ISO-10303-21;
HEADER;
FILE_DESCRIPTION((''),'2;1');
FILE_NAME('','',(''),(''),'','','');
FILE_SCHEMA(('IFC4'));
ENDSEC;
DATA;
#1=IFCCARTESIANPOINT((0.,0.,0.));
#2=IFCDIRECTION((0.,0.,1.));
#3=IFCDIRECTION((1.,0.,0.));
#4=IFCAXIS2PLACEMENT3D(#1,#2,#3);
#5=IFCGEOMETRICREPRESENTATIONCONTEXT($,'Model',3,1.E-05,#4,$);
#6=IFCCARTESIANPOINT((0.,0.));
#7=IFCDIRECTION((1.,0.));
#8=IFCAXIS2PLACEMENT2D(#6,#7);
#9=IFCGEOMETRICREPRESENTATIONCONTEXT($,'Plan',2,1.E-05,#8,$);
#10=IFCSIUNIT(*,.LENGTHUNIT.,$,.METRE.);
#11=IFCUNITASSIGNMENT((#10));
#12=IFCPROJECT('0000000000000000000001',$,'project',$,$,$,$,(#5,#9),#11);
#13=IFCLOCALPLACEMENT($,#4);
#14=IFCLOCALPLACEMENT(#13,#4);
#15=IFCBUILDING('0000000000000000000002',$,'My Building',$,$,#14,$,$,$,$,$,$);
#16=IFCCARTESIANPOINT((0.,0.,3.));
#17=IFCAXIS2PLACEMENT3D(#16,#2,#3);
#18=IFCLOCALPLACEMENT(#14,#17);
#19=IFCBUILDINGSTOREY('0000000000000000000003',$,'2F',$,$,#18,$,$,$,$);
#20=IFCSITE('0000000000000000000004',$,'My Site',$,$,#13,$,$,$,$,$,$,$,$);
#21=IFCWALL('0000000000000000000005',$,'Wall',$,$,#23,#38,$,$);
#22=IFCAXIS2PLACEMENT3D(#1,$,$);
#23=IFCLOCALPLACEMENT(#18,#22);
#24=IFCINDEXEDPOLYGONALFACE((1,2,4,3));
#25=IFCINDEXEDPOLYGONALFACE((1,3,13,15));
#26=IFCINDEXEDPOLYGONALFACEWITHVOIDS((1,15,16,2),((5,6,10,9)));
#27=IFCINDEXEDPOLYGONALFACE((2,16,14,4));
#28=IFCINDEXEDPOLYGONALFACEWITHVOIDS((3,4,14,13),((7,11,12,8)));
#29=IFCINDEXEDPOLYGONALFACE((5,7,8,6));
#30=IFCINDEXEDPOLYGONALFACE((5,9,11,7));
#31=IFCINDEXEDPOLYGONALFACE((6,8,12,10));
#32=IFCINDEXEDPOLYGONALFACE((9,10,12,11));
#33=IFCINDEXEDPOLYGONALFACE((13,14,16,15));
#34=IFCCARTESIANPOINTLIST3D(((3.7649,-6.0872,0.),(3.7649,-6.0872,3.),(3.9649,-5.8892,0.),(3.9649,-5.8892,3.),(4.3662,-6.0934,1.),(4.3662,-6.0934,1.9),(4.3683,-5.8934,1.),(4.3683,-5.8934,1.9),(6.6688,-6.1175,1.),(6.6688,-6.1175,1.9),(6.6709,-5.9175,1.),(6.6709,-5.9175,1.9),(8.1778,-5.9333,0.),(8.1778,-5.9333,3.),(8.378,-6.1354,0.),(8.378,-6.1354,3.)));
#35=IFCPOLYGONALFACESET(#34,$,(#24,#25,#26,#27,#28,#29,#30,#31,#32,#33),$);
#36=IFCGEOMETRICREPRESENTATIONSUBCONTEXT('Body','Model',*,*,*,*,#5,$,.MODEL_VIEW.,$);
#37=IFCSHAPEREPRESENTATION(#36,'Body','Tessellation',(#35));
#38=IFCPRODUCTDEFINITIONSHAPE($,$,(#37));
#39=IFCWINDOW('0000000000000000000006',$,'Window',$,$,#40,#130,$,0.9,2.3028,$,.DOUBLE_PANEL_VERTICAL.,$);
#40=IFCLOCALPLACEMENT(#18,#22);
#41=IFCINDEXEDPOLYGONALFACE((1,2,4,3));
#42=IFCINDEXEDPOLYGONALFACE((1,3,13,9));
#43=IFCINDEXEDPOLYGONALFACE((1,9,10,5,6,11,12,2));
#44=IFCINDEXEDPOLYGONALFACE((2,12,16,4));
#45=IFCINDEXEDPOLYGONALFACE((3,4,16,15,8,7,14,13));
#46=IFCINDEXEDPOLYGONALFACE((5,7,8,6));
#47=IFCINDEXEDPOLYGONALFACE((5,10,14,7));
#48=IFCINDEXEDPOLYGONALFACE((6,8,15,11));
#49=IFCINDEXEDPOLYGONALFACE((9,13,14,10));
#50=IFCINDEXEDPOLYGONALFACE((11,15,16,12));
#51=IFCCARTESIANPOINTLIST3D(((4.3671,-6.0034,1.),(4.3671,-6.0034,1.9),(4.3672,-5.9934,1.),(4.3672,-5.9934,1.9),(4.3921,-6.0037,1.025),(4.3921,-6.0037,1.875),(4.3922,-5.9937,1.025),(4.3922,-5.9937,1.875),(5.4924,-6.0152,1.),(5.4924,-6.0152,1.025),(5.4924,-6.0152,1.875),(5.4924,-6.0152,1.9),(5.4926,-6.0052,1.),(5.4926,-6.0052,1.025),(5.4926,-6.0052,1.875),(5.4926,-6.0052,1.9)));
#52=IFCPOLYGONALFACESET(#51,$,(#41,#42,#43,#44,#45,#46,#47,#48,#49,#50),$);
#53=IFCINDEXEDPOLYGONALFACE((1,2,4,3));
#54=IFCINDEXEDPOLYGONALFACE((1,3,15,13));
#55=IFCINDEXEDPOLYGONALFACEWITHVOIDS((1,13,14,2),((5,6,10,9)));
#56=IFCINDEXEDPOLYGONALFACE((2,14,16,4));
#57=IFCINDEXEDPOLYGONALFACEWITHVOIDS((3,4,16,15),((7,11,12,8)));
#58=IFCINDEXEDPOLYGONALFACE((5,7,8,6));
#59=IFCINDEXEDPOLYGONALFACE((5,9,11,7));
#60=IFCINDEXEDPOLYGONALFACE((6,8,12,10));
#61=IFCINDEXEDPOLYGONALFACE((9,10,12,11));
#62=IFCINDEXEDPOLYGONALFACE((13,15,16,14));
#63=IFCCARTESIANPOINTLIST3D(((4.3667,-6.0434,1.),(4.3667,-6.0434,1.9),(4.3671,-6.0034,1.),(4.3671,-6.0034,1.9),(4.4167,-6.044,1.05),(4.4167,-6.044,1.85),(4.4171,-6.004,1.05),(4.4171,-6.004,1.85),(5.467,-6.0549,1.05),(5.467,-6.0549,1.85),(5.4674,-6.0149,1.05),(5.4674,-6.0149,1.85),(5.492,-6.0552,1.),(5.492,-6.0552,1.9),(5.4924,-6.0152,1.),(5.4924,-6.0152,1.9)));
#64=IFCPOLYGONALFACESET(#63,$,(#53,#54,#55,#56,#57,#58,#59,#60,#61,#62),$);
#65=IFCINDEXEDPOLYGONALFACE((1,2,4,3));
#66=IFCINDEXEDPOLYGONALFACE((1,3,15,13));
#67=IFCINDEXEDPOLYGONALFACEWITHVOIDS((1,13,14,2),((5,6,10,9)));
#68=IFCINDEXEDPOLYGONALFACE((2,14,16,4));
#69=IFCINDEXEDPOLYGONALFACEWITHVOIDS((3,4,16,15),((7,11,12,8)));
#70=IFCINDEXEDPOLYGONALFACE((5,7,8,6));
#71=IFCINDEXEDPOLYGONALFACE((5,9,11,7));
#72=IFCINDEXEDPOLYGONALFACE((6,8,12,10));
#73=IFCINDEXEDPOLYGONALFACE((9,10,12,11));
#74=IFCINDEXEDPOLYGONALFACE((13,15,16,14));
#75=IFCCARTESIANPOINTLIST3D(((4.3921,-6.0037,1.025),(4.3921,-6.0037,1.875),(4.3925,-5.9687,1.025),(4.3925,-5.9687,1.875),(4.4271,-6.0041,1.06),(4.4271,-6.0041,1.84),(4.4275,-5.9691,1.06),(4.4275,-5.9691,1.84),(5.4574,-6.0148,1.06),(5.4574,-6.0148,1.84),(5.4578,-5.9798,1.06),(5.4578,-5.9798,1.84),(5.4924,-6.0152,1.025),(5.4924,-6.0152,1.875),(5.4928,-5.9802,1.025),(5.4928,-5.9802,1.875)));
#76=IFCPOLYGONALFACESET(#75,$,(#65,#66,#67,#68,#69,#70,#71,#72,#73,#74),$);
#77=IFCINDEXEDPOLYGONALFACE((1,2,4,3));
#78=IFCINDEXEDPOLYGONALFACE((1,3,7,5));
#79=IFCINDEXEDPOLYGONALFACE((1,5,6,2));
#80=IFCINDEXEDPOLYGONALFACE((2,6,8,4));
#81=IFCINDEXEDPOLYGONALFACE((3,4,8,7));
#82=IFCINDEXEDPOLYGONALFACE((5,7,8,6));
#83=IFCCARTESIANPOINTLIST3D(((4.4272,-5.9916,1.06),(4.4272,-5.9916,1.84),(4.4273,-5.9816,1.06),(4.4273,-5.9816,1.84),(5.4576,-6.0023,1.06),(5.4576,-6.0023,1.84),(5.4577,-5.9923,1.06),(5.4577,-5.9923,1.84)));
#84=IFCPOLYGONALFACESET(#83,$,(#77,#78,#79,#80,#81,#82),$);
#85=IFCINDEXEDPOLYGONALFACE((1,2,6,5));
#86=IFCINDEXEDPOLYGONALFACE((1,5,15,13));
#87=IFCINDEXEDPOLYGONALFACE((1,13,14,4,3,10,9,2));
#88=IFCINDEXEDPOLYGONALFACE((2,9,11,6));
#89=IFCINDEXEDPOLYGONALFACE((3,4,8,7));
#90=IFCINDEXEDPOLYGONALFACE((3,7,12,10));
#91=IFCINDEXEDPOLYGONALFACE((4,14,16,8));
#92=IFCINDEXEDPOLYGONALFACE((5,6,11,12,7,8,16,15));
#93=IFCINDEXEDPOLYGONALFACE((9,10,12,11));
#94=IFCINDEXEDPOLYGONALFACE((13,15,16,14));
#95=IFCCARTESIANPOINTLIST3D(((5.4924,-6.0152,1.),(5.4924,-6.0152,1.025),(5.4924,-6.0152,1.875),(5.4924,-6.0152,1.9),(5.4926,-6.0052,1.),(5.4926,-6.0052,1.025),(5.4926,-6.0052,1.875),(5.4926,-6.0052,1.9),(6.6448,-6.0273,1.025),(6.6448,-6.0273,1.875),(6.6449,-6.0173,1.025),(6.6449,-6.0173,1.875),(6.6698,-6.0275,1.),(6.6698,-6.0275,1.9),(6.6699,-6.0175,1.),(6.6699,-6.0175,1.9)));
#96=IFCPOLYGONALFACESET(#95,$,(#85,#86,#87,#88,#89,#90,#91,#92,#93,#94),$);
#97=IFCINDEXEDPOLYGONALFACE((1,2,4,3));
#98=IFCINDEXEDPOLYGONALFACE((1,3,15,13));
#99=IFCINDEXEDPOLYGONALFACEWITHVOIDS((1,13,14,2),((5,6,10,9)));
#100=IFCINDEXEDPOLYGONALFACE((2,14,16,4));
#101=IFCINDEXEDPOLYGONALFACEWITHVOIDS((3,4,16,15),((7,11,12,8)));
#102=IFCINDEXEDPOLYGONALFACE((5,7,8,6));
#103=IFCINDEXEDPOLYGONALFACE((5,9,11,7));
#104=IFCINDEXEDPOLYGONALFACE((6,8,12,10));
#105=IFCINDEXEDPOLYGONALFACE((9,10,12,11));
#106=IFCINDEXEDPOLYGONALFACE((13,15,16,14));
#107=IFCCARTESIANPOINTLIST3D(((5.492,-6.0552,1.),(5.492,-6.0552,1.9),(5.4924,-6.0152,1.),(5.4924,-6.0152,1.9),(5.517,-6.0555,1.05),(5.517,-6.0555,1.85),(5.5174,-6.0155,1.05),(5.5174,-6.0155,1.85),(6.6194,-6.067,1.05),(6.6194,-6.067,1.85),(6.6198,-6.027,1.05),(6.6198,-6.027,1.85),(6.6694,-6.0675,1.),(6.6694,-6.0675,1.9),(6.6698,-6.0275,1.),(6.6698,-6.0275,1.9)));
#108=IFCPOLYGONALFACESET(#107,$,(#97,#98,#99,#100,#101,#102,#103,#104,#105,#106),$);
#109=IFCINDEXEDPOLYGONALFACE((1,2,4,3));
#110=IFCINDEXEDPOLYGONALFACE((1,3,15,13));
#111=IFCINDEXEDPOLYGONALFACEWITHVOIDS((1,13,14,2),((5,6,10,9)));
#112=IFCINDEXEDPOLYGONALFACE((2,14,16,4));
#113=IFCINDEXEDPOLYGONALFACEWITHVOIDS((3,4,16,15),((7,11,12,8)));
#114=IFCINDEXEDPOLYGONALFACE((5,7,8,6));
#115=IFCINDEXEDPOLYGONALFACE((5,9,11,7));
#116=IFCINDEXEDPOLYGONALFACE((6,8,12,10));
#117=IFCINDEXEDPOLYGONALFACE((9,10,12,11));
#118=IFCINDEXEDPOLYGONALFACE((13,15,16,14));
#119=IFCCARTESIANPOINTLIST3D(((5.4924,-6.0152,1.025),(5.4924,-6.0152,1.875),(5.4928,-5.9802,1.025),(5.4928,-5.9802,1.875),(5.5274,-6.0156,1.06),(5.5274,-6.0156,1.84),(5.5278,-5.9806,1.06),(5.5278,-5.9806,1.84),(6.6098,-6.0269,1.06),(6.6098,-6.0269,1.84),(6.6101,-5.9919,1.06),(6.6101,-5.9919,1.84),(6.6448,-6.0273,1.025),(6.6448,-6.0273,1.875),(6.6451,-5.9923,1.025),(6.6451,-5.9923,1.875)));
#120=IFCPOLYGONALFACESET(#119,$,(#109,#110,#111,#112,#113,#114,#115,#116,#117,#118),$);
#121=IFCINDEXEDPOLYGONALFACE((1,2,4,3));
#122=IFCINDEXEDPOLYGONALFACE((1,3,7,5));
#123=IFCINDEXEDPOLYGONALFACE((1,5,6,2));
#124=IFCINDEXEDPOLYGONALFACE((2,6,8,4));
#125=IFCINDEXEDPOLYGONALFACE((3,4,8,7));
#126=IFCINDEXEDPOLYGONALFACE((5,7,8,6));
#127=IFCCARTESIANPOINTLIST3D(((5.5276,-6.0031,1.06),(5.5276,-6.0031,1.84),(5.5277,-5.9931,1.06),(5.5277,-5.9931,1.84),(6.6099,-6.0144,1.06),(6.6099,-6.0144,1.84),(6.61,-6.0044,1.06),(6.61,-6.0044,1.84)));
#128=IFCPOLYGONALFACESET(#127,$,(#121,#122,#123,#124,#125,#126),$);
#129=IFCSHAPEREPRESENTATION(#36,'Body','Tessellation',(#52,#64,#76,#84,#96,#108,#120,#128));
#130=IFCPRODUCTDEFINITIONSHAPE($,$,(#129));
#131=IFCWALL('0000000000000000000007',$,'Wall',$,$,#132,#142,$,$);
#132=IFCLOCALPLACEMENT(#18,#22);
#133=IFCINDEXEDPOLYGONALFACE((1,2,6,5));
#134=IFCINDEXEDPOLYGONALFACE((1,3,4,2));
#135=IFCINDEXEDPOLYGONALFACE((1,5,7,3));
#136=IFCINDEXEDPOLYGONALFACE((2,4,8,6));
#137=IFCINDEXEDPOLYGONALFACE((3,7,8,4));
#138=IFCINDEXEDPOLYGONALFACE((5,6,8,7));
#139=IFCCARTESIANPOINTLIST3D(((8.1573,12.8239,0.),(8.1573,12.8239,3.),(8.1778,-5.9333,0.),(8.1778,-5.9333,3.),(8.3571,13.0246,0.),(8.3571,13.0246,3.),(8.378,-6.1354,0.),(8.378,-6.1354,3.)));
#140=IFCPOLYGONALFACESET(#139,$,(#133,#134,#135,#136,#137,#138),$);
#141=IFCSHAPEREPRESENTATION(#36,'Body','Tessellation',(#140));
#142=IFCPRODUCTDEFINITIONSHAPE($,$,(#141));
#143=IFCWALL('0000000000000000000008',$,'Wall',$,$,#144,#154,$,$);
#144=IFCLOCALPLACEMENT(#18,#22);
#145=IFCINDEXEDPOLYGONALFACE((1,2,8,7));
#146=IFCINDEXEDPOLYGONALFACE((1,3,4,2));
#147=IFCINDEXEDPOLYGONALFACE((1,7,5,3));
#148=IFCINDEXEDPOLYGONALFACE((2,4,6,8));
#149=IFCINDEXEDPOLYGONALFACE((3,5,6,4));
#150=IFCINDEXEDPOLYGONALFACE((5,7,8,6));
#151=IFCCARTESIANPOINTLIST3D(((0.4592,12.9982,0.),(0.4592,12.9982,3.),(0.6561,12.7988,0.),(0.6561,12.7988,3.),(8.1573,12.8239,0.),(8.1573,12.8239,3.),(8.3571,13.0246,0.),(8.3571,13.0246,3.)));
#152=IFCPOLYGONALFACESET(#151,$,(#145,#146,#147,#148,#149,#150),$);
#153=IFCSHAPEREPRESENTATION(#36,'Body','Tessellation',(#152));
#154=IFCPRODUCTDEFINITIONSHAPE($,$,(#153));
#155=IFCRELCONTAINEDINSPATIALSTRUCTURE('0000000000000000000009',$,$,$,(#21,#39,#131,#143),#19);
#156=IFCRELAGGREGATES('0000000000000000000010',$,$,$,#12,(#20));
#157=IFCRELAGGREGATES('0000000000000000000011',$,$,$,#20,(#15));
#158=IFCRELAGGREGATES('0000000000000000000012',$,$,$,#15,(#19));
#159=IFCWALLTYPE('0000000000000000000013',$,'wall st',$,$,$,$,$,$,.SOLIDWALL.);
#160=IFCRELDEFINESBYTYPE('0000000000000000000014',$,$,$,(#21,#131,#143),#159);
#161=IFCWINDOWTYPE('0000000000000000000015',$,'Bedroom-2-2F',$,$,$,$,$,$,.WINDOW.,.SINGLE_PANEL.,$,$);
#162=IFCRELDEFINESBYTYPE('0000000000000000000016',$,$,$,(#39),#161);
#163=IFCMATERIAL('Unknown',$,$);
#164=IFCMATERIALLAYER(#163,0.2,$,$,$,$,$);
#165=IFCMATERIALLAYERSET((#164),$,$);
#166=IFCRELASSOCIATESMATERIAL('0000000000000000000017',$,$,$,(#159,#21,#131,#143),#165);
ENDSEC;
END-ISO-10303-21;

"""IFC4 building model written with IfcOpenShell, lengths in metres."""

from ifc_helpers import new_model, entity, si_unit, frame, origin_with_axes, origin_2d_with_axis, place, context, subcontext, project, spatial, line, indexed_curve, outline, extrude, shape, source, transform, mapped, material, layer, layer_set, layer_usage, type_object, type_shapes, element, fill, save


model = new_model("IFC4")

# Units and contexts
model_context = context("Model", 3, precision=1e-05, world=origin_with_axes())
plan_context = context("Plan", 2, precision=1e-05, world=origin_2d_with_axis())
body_context_1 = subcontext(model_context, "Body", "Model", "MODEL_VIEW")
body_context_2 = subcontext(plan_context, "Body", "Plan", "PLAN_VIEW")
ifc_project = project(units=[si_unit("LENGTHUNIT", "METRE")], contexts=[model_context, plan_context])

# Site, building, storey
site_placement = place(None, origin_with_axes())
site = spatial("IfcSite", under=ifc_project, at=site_placement, Name="My Site")
building_placement = place(site_placement, origin_with_axes())
building = spatial("IfcBuilding", under=site, at=building_placement, Name="My Building")
storey_placement = place(building_placement, frame((0.0, 0.0, 3.0), z_axis=(0.0, 0.0, 1.0), x_axis=(1.0, 0.0, 0.0)))
storey = spatial("IfcBuildingStorey", under=building, at=storey_placement, Name="2F")

# Shared definitions
ifc_material = material(Name="Unknown")

# Shared definitions
ifc_layer_1 = layer(ifc_material, 0.2)
ifc_layer_set_1 = layer_set([ifc_layer_1])
wall_type_1 = type_object("IfcWallType", Name="wall st", PredefinedType="SOLIDWALL", material=ifc_layer_set_1)

# Wall, opening, window
ifc_layer_usage_1 = layer_usage(ifc_layer_set_1, "AXIS2", "POSITIVE", 0.0)
wall_1_placement = place(storey_placement, frame((3.7649, -6.0872, 0.0), z_axis=(0.0, 0.0, 1.0), x_axis=(0.999945, -0.010453, 0.0)))
wall_1 = element("IfcWall", 1, at=wall_1_placement, inside=storey, type_object=wall_type_1, material=ifc_layer_usage_1, Name="Wall", context=body_context_1, shape_type="SweptSolid", body=[
    extrude(outline(indexed_curve([(0.0, 0.0), (0.1979, 0.2), (4.4111, 0.2), (4.6134, 0.0)], segments=[line(1, 2, 3, 4, 1)])), origin_with_axes(), (0.0, 0.0, 1.0), 3.0),
])
shared_shape_1 = source(origin_with_axes(), body_context_1, "Body", "SweptSolid", [
    extrude(outline(indexed_curve([(0.0, 0.0), (2.3028, 0.0), (2.3028, 0.9), (0.0, 0.9)], segments=[line(1, 2, 3, 4, 1)])), frame((0.0, -0.6, 0.0), z_axis=(0.0, -1.0, 0.0), x_axis=(1.0, 0.0, 0.0)), (0.0, 0.0, -1.0), 1.2),
])
opening_1_placement = place(wall_1_placement, frame((0.6013, 0.0, 1.0), z_axis=(0.0, 0.0, 1.0), x_axis=(1.0, 0.0, 0.0)))
opening_1 = element("IfcOpeningElement", 2, at=opening_1_placement, cuts=wall_1, PredefinedType="OPENING", context=body_context_1, shape_type="MappedRepresentation", body=[
    mapped(shared_shape_1, transform((0.0, 0.0, 0.0), x_axis=(1.0, 0.0, 0.0), y_axis=(0.0, 1.0, 0.0), z_axis=(0.0, 0.0, 1.0), scale=1.0)),
])
window_type_1 = type_object("IfcWindowType", Name="Bedroom-2-2F", PartitioningType="SINGLE_PANEL", PredefinedType="WINDOW")
shared_shape_2 = source(origin_with_axes(), body_context_1, "Body", "SweptSolid", [
    extrude(outline(indexed_curve([(1.1254, 0.0), (0.0, 0.0), (0.0, 0.9), (1.1254, 0.9), (1.1254, 0.875), (0.025, 0.875), (0.025, 0.025), (1.1254, 0.025)], segments=[line(1, 2, 3, 4, 5, 6, 7, 8, 1)])), frame((0.0, 0.09, 0.0), z_axis=(0.0, -1.0, 0.0), x_axis=(1.0, 0.0, 0.0)), (0.0, 0.0, -1.0), 0.01),
    extrude(outline(indexed_curve([(0.0, 0.0), (1.1254, 0.0), (1.1254, 0.9), (0.0, 0.9)], segments=[line(1, 2, 3, 4, 1)]), holes=[indexed_curve([(0.05, 0.05), (1.1004, 0.05), (1.1004, 0.85), (0.05, 0.85)], segments=[line(1, 2, 3, 4, 1)])]), frame((0.0, 0.05, 0.0), z_axis=(0.0, -1.0, 0.0), x_axis=(1.0, 0.0, 0.0)), (0.0, 0.0, -1.0), 0.04),
    extrude(outline(indexed_curve([(0.0, 0.0), (1.1004, 0.0), (1.1004, 0.85), (0.0, 0.85)], segments=[line(1, 2, 3, 4, 1)]), holes=[indexed_curve([(0.035, 0.035), (1.0654, 0.035), (1.0654, 0.815), (0.035, 0.815)], segments=[line(1, 2, 3, 4, 1)])]), frame((0.025, 0.09, 0.025), z_axis=(0.0, -1.0, 0.0), x_axis=(1.0, 0.0, 0.0)), (0.0, 0.0, -1.0), 0.035),
    extrude(outline(indexed_curve([(0.035, 0.035), (1.0654, 0.035), (1.0654, 0.815), (0.035, 0.815)], segments=[line(1, 2, 3, 4, 1)])), frame((0.025, 0.1025, 0.025), z_axis=(0.0, -1.0, 0.0), x_axis=(1.0, 0.0, 0.0)), (0.0, 0.0, -1.0), 0.01),
    extrude(outline(indexed_curve([(0.0, 0.9), (1.1774, 0.9), (1.1774, 0.0), (0.0, 0.0), (0.0, 0.025), (1.1524, 0.025), (1.1524, 0.875), (0.0, 0.875)], segments=[line(1, 2, 3, 4, 5, 6, 7, 8, 1)])), frame((1.1254, 0.09, 0.0), z_axis=(0.0, -1.0, 0.0), x_axis=(1.0, 0.0, 0.0)), (0.0, 0.0, -1.0), 0.01),
    extrude(outline(indexed_curve([(0.0, 0.0), (1.1774, 0.0), (1.1774, 0.9), (0.0, 0.9)], segments=[line(1, 2, 3, 4, 1)]), holes=[indexed_curve([(0.025, 0.05), (1.1274, 0.05), (1.1274, 0.85), (0.025, 0.85)], segments=[line(1, 2, 3, 4, 1)])]), frame((1.1254, 0.05, 0.0), z_axis=(0.0, -1.0, 0.0), x_axis=(1.0, 0.0, 0.0)), (0.0, 0.0, -1.0), 0.04),
    extrude(outline(indexed_curve([(0.0, 0.0), (1.1524, 0.0), (1.1524, 0.85), (0.0, 0.85)], segments=[line(1, 2, 3, 4, 1)]), holes=[indexed_curve([(0.035, 0.035), (1.1174, 0.035), (1.1174, 0.815), (0.035, 0.815)], segments=[line(1, 2, 3, 4, 1)])]), frame((1.1254, 0.09, 0.025), z_axis=(0.0, -1.0, 0.0), x_axis=(1.0, 0.0, 0.0)), (0.0, 0.0, -1.0), 0.035),
    extrude(outline(indexed_curve([(0.035, 0.035), (1.1174, 0.035), (1.1174, 0.815), (0.035, 0.815)], segments=[line(1, 2, 3, 4, 1)])), frame((1.1254, 0.1025, 0.025), z_axis=(0.0, -1.0, 0.0), x_axis=(1.0, 0.0, 0.0)), (0.0, 0.0, -1.0), 0.01),
])
shared_shape_3 = source(origin_with_axes(), body_context_2, "Body", "Curve2D", [
    entity("IfcIndexedPolyCurve", entity("IfcCartesianPointList2D", [[0.05, 0.05], [1.1004, 0.05]])),
    entity("IfcIndexedPolyCurve", entity("IfcCartesianPointList2D", [[0.0, 0.1], [0.025, 0.1], [0.025, 0.09], [0.05, 0.09], [0.05, 0.05], [0.0, 0.05]]), [entity("IfcLineIndex", [1, 2, 3, 4, 5, 6, 1])]),
    entity("IfcIndexedPolyCurve", entity("IfcCartesianPointList2D", [[1.1254, 0.1], [1.1254, 0.1], [1.1254, 0.09], [1.1004, 0.09], [1.1004, 0.05], [1.1254, 0.05]])),
    entity("IfcIndexedPolyCurve", entity("IfcCartesianPointList2D", [[0.025, 0.09], [0.06, 0.09], [0.06, 0.125], [0.025, 0.125]]), [entity("IfcLineIndex", [1, 2, 3, 4, 1])]),
    entity("IfcIndexedPolyCurve", entity("IfcCartesianPointList2D", [[1.1254, 0.09], [1.0904, 0.09], [1.0904, 0.125], [1.1254, 0.125]]), [entity("IfcLineIndex", [1, 2, 3, 4, 1])]),
    entity("IfcIndexedPolyCurve", entity("IfcCartesianPointList2D", [[0.06, 0.09], [1.0904, 0.09]])),
    entity("IfcIndexedPolyCurve", entity("IfcCartesianPointList2D", [[0.06, 0.125], [1.0904, 0.125]])),
    entity("IfcIndexedPolyCurve", entity("IfcCartesianPointList2D", [[0.06, 0.1075], [1.0904, 0.1075]])),
    entity("IfcIndexedPolyCurve", entity("IfcCartesianPointList2D", [[1.1504, 0.05], [2.2528, 0.05]])),
    entity("IfcIndexedPolyCurve", entity("IfcCartesianPointList2D", [[1.1254, 0.1], [1.1254, 0.1], [1.1254, 0.09], [1.1504, 0.09], [1.1504, 0.05], [1.1254, 0.05]])),
    entity("IfcIndexedPolyCurve", entity("IfcCartesianPointList2D", [[2.3028, 0.1], [2.2778, 0.1], [2.2778, 0.09], [2.2528, 0.09], [2.2528, 0.05], [2.3028, 0.05]]), [entity("IfcLineIndex", [1, 2, 3, 4, 5, 6, 1])]),
    entity("IfcIndexedPolyCurve", entity("IfcCartesianPointList2D", [[1.1254, 0.09], [1.1604, 0.09], [1.1604, 0.125], [1.1254, 0.125]]), [entity("IfcLineIndex", [1, 2, 3, 4, 1])]),
    entity("IfcIndexedPolyCurve", entity("IfcCartesianPointList2D", [[2.2778, 0.09], [2.2428, 0.09], [2.2428, 0.125], [2.2778, 0.125]]), [entity("IfcLineIndex", [1, 2, 3, 4, 1])]),
    entity("IfcIndexedPolyCurve", entity("IfcCartesianPointList2D", [[1.1604, 0.09], [2.2428, 0.09]])),
    entity("IfcIndexedPolyCurve", entity("IfcCartesianPointList2D", [[1.1604, 0.125], [2.2428, 0.125]])),
    entity("IfcIndexedPolyCurve", entity("IfcCartesianPointList2D", [[1.1604, 0.1075], [2.2428, 0.1075]])),
])
type_shapes(window_type_1, [shared_shape_2, shared_shape_3])
window_1_placement = place(opening_1_placement, frame((0.0, 0.0, 0.0), z_axis=(0.0, 0.0, 1.0), x_axis=(1.0, 0.0, 0.0)))
window_1 = element("IfcWindow", 3, at=window_1_placement, inside=storey, type_object=window_type_1, Name="Window", OverallHeight=0.9, OverallWidth=2.3028, PartitioningType="DOUBLE_PANEL_VERTICAL", shapes=[
    shape(body_context_1, "Body", "MappedRepresentation", [mapped(shared_shape_2, transform((0.0, 0.0, 0.0), x_axis=(1.0, 0.0, 0.0), y_axis=(0.0, 1.0, 0.0), z_axis=(0.0, 0.0, 1.0), scale=1.0))]),
    shape(body_context_2, "Body", "MappedRepresentation", [mapped(shared_shape_3, transform((0.0, 0.0, 0.0), x_axis=(1.0, 0.0, 0.0), y_axis=(0.0, 1.0, 0.0), z_axis=(0.0, 0.0, 1.0), scale=1.0))]),
])
fill(opening_1, window_1)

# Walls
ifc_layer_usage_2 = layer_usage(ifc_layer_set_1, "AXIS2", "POSITIVE", 0.0)
wall_2_placement = place(storey_placement, frame((8.378, -6.1354, 0.0), z_axis=(0.0, 0.0, 1.0), x_axis=(-0.001091, 0.999999, 0.0)))
element("IfcWall", 4, at=wall_2_placement, inside=storey, type_object=wall_type_1, material=ifc_layer_usage_2, Name="Wall", context=body_context_1, shape_type="SweptSolid", body=[
    extrude(outline(indexed_curve([(0.0, 0.0), (0.2023, 0.2), (18.9595, 0.2), (19.1599, 0.0)], segments=[line(1, 2, 3, 4, 1)])), origin_with_axes(), (0.0, 0.0, 1.0), 3.0),
])
ifc_layer_usage_3 = layer_usage(ifc_layer_set_1, "AXIS2", "POSITIVE", 0.0)
wall_3_placement = place(storey_placement, frame((8.3571, 13.0246, 0.0), z_axis=(0.0, 0.0, 1.0), x_axis=(-0.999994, -0.00334, 0.0)))
element("IfcWall", 5, at=wall_3_placement, inside=storey, type_object=wall_type_1, material=ifc_layer_usage_3, Name="Wall", context=body_context_1, shape_type="SweptSolid", body=[
    extrude(outline(indexed_curve([(0.0, 0.0), (0.2005, 0.2), (7.7017, 0.2), (7.898, 0.0)], segments=[line(1, 2, 3, 4, 1)])), origin_with_axes(), (0.0, 0.0, 1.0), 3.0),
])

save(model, "model.ifc")
